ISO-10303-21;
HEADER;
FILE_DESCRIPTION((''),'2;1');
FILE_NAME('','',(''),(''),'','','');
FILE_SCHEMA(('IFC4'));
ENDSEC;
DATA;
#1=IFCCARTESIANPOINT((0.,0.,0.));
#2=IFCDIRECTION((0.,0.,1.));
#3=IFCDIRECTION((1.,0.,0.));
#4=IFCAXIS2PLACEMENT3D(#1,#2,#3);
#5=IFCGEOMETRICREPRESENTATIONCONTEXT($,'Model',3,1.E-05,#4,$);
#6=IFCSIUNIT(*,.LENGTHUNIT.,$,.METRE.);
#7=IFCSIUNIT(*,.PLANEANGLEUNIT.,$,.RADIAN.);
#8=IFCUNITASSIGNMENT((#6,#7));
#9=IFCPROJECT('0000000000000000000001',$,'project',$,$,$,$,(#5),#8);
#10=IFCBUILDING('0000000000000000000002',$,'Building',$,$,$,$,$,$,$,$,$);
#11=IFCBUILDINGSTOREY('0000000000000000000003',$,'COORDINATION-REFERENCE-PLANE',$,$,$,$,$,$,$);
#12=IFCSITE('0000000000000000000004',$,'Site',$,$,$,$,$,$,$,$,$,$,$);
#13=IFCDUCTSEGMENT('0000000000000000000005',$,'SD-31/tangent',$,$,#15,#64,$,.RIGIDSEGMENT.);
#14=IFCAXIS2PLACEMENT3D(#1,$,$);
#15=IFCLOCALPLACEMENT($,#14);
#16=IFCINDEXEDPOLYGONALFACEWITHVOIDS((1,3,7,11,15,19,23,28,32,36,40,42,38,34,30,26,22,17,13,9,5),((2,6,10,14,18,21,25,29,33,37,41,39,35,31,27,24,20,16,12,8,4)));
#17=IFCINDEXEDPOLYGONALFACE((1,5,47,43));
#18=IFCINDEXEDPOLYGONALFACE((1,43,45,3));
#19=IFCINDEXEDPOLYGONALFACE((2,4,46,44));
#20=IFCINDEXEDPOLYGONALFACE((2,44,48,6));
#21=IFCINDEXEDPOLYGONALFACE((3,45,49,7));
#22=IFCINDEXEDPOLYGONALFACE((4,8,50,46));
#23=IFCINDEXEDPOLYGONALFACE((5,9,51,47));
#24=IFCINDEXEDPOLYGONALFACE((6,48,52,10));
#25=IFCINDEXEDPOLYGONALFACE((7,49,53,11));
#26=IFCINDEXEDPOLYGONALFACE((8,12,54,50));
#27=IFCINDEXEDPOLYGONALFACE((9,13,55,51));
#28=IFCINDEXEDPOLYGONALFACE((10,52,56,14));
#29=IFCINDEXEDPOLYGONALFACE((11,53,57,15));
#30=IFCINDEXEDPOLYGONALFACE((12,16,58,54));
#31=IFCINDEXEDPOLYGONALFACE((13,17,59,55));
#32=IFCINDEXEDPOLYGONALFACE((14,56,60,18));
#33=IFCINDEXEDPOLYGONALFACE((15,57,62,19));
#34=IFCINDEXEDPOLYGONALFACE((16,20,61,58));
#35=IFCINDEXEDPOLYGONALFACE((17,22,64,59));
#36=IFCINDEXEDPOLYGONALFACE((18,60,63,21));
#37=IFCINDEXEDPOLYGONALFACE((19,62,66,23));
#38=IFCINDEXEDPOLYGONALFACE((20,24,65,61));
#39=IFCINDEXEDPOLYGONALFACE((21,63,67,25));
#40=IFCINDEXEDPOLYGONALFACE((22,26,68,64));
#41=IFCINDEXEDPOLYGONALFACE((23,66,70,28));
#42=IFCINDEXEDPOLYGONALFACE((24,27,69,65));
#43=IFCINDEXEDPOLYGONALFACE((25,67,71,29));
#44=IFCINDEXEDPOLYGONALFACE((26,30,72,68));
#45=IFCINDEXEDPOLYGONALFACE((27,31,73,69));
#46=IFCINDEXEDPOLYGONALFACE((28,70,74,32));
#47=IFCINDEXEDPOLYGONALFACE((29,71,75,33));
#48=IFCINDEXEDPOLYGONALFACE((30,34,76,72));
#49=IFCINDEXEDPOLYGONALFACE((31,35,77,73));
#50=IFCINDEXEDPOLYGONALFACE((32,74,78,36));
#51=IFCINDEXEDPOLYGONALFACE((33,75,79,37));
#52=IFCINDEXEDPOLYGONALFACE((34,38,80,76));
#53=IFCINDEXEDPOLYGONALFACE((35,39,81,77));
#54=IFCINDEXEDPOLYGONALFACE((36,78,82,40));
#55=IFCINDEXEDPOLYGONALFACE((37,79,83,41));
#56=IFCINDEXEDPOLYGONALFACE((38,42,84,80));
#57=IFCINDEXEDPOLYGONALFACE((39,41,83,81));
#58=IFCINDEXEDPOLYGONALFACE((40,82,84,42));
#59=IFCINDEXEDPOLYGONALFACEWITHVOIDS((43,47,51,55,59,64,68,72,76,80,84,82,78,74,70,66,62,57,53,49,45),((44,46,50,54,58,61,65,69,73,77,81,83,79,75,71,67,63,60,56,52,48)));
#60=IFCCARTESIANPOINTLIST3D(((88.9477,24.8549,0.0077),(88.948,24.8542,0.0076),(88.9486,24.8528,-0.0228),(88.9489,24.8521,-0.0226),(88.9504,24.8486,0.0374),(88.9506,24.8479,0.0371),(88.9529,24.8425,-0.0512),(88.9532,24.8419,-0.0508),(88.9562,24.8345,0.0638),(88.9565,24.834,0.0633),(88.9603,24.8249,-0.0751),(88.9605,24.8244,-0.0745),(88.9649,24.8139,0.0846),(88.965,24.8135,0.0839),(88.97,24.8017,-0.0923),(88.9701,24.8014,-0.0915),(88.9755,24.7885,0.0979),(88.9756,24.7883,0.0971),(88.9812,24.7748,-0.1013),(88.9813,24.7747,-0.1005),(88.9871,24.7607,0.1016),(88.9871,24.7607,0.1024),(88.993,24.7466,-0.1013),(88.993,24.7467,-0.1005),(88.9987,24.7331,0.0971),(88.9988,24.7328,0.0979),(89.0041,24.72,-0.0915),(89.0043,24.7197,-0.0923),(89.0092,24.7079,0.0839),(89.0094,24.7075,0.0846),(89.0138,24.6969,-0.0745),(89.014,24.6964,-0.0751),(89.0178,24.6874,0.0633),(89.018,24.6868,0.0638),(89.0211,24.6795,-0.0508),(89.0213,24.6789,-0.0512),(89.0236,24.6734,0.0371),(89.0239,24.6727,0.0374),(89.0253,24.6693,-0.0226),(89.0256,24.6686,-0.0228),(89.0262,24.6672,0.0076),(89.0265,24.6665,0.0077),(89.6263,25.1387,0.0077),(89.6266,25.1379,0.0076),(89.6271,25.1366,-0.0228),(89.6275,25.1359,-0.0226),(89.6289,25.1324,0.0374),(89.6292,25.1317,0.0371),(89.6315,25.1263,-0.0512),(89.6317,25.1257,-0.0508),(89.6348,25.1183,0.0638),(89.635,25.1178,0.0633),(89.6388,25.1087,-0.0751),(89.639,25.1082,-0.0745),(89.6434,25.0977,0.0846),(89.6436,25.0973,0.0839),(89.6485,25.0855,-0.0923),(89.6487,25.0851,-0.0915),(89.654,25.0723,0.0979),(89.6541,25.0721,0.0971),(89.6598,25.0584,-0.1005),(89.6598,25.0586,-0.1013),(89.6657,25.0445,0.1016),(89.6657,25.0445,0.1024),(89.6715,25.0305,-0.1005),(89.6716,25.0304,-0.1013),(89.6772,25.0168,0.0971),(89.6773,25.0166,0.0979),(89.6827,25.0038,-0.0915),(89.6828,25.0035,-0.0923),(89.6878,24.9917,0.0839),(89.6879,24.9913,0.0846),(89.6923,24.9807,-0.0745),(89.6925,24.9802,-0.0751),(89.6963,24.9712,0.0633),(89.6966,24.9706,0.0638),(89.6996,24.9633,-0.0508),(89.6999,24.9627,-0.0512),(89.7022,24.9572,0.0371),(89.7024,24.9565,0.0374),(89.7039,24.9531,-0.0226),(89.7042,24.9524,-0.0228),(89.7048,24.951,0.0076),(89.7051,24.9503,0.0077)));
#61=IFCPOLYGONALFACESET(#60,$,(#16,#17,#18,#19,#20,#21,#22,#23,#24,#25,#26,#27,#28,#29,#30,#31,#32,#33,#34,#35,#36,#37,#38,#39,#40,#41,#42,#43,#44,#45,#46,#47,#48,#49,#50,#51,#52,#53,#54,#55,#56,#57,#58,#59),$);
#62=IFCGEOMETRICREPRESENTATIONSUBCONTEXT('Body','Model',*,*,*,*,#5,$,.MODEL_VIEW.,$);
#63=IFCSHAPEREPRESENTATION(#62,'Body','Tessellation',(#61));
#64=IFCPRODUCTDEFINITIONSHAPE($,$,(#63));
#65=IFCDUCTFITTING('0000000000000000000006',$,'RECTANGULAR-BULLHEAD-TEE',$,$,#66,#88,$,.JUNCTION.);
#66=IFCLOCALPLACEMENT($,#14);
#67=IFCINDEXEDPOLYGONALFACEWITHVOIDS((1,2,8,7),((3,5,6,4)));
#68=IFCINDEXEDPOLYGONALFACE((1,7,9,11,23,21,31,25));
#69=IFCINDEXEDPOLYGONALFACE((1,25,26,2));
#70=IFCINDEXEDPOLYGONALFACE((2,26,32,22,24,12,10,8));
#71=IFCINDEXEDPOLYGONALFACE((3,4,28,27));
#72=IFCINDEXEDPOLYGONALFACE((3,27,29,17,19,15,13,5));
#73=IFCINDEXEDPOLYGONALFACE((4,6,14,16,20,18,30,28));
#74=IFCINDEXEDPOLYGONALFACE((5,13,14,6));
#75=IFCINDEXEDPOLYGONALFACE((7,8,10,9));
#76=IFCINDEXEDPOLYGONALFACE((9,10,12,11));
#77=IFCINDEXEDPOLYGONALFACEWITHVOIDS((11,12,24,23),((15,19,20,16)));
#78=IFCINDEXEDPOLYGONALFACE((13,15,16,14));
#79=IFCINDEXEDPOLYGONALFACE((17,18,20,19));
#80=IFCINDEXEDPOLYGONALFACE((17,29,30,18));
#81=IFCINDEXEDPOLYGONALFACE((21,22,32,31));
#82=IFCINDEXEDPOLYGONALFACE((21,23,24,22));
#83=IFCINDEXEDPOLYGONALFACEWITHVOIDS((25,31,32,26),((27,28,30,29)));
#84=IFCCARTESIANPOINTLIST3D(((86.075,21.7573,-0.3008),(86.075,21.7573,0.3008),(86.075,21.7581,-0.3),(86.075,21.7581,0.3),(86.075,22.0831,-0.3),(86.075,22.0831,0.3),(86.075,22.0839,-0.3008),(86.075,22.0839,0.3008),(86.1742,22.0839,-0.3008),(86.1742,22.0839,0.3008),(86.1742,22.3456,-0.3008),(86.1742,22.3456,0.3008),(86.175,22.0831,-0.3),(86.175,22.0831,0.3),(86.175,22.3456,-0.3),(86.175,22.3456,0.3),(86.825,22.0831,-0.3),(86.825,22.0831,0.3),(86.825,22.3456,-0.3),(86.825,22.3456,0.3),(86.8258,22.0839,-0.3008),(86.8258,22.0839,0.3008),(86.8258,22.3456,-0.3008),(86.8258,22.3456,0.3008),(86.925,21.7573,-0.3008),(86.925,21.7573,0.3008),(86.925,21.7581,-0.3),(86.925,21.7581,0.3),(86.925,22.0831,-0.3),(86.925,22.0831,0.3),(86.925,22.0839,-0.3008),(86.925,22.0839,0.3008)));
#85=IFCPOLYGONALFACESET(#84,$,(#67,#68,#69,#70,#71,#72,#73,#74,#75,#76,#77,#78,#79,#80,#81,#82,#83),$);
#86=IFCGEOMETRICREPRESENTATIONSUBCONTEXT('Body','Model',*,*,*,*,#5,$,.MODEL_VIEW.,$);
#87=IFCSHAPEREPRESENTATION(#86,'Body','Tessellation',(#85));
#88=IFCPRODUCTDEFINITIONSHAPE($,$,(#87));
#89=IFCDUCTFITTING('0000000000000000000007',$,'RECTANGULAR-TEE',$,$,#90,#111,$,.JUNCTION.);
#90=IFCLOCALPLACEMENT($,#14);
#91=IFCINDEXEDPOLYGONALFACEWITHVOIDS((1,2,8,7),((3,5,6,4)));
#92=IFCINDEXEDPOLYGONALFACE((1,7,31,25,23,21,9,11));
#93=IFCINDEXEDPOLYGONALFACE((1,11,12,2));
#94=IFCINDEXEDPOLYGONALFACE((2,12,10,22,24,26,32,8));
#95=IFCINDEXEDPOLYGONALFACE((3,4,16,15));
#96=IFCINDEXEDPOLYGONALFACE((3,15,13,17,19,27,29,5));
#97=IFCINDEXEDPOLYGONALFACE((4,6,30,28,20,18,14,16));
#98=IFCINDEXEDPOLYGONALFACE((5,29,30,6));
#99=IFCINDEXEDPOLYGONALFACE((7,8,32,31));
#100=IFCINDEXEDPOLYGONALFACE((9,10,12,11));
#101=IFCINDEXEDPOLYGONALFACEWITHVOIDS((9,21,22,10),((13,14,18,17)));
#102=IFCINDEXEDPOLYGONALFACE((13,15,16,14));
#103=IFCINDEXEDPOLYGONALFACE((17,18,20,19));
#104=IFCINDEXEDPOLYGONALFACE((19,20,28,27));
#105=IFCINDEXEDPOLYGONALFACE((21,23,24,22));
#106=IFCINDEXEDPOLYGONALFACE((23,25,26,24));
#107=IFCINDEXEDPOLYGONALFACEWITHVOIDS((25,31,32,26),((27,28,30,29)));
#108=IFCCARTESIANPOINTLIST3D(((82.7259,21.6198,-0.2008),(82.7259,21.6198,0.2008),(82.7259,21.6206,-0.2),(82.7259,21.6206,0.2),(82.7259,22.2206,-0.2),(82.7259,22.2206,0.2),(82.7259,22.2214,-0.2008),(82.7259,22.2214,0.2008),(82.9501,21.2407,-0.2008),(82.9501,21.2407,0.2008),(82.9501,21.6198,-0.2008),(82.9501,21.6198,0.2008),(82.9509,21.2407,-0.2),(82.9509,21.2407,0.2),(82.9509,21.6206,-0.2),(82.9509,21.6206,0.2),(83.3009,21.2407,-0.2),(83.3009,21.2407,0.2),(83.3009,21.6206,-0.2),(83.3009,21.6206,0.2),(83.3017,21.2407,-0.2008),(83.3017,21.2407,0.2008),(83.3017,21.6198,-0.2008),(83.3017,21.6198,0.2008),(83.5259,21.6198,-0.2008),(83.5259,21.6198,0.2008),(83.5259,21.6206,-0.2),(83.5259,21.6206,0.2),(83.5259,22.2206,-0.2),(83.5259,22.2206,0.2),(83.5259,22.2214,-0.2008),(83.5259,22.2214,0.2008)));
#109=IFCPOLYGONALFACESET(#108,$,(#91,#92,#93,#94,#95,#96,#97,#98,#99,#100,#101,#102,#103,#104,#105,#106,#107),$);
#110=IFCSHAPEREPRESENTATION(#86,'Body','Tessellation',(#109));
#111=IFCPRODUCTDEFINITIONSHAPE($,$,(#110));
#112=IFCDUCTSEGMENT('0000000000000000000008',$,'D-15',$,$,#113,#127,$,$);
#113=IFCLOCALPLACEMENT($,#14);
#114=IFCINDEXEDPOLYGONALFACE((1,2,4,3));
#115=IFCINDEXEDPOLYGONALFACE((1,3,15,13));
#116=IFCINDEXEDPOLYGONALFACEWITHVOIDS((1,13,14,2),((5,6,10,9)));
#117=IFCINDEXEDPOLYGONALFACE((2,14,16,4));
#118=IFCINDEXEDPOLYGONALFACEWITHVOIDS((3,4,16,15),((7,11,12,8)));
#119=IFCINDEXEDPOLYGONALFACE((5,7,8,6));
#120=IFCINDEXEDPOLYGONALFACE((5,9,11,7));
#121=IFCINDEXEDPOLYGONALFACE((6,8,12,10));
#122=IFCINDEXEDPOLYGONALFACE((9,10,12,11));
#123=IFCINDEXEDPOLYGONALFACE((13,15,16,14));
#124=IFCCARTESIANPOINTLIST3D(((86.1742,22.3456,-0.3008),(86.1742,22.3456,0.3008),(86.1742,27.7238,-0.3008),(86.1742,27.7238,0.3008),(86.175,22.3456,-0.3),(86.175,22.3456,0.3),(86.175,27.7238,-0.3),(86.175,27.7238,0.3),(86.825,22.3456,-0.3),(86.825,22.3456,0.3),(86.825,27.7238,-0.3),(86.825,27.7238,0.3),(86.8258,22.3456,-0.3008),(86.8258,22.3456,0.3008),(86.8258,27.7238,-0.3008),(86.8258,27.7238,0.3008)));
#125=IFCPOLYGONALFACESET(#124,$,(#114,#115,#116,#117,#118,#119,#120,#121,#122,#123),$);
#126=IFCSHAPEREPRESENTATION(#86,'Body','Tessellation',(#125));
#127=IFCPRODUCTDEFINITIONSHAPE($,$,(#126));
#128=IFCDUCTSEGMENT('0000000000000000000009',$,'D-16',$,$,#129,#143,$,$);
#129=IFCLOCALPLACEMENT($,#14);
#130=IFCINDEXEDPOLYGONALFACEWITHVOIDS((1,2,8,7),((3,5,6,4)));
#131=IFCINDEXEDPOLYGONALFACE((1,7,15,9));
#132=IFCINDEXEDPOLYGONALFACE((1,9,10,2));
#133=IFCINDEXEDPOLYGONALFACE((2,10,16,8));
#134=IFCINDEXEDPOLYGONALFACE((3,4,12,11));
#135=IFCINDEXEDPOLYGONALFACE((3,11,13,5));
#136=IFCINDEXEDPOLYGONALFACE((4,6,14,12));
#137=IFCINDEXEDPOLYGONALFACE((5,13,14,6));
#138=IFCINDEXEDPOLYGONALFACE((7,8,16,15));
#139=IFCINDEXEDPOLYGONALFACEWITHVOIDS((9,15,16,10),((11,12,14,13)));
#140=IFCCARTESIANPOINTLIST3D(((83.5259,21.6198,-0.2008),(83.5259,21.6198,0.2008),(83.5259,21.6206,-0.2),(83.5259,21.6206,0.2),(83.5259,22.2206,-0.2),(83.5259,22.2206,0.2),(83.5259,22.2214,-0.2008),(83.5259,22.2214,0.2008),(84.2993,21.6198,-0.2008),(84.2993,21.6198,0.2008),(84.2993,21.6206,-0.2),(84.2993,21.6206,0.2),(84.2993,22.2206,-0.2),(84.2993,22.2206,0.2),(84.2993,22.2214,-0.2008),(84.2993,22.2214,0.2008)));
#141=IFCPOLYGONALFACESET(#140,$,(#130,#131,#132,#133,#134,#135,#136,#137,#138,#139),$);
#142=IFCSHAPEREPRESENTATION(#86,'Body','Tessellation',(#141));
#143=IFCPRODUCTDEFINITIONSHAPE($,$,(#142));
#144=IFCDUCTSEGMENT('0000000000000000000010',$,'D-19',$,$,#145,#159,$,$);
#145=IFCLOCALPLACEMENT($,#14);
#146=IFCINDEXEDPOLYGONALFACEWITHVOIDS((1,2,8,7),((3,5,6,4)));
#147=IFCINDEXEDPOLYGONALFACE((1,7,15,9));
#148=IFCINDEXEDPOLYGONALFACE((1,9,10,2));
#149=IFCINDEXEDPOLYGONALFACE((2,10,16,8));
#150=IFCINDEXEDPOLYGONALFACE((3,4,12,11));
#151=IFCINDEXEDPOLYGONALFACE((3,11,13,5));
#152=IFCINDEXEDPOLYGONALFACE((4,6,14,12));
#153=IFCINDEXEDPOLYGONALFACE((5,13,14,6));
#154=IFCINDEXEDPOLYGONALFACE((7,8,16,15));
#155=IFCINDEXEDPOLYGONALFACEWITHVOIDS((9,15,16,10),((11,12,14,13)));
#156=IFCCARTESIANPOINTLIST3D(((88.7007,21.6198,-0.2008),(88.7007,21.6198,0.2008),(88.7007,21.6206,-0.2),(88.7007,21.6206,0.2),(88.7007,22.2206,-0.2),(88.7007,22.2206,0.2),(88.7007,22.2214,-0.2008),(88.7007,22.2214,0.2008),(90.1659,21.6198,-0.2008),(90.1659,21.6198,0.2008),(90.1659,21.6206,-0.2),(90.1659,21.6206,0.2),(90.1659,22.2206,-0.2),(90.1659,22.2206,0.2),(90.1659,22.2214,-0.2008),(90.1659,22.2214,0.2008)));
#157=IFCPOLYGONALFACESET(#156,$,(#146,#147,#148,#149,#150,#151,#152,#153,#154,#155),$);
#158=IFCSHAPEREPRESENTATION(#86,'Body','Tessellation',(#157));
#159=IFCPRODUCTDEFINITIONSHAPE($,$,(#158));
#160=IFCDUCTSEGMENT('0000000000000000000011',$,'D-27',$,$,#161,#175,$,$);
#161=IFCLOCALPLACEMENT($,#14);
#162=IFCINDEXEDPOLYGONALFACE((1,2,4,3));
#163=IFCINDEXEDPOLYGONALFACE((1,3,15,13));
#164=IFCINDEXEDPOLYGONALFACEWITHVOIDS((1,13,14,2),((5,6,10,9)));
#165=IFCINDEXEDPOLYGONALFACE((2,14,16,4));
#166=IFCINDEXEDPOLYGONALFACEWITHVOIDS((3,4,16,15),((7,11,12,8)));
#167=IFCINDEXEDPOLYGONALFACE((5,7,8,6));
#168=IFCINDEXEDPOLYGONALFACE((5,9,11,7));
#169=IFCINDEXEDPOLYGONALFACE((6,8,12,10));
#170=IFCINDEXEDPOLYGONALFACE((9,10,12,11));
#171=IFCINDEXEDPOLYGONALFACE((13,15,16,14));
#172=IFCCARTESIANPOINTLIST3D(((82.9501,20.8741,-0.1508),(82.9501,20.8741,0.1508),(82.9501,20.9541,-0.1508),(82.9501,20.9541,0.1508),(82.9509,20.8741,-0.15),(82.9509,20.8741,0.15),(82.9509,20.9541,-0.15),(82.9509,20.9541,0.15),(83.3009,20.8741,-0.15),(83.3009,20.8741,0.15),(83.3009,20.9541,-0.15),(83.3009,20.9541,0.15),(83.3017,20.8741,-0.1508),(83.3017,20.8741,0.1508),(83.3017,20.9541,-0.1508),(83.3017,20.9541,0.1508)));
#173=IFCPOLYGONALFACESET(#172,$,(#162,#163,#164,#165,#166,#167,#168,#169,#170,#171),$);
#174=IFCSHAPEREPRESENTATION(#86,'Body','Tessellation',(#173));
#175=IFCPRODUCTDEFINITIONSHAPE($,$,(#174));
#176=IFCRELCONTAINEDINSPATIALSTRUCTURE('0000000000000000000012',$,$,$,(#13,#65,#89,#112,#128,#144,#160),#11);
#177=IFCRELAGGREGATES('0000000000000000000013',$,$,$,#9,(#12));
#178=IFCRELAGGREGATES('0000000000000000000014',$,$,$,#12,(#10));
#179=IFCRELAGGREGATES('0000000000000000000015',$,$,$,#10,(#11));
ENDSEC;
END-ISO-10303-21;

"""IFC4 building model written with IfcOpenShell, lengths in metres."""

from ifc_helpers import new_model, si_unit, frame, origin, origin_with_axes, place, context, subcontext, project, spatial, rectangle, hollow_rectangle, hollow_circle, extrude, boolean, element, save


model = new_model("IFC4")

# Units and contexts
model_context = context("Model", 3, precision=1e-05, world=origin_with_axes())
body_context_1 = subcontext(model_context, "Body", "Model", "MODEL_VIEW")
body_context_2 = subcontext(model_context, "Body", "Model", "MODEL_VIEW")
ifc_project = project(units=[si_unit("LENGTHUNIT", "METRE"), si_unit("PLANEANGLEUNIT", "RADIAN")], contexts=[model_context])

# Site, building, storey
site = spatial("IfcSite", under=ifc_project, Name="Site")
building = spatial("IfcBuilding", under=site, Name="Building")
storey = spatial("IfcBuildingStorey", under=building, Name="COORDINATION-REFERENCE-PLANE")

# Duct segment
duct_segment_1_placement = place(None, frame((89.6657, 25.0445, 0.0), z_axis=(-0.922564, -0.385845, 0.0), x_axis=(0.0, 0.0, 1.0)))
element("IfcDuctSegment", 1, at=duct_segment_1_placement, inside=storey, Name="SD-31/tangent", PredefinedType="RIGIDSEGMENT", context=body_context_1, shape_type="SweptSolid", body=[
    extrude(hollow_circle(Radius=0.1024, WallThickness=0.0008), origin_with_axes(), (0.0, 0.0, 1.0), 0.7355),
])

# Duct fittings
duct_fitting_1_placement = place(None, frame((86.5, 21.9206, 0.0), z_axis=(1.0, 0.0, 0.0), x_axis=(0.0, 1.0, 0.0)))
solid_1 = boolean("UNION", extrude(rectangle(XDim=0.325, YDim=0.6), frame((0.0, 0.0, -0.425), z_axis=(0.0, 0.0, 1.0), x_axis=(1.0, 0.0, 0.0)), (0.0, 0.0, 1.0), 0.85), extrude(rectangle(XDim=0.65, YDim=0.6), frame((0.0, 0.0, 0.0), z_axis=(1.0, 0.0, 0.0), x_axis=(0.0, 0.0, -1.0)), (0.0, 0.0, 1.0), 0.425))
element("IfcDuctFitting", 2, at=duct_fitting_1_placement, inside=storey, Name="RECTANGULAR-BULLHEAD-TEE", PredefinedType="JUNCTION", context=body_context_2, shape_type="CSG", body=[
    boolean("DIFFERENCE", boolean("UNION", extrude(rectangle(XDim=0.3266, YDim=0.6016), frame((0.0, 0.0, -0.425), z_axis=(0.0, 0.0, 1.0), x_axis=(1.0, 0.0, 0.0)), (0.0, 0.0, 1.0), 0.85), extrude(rectangle(XDim=0.6516, YDim=0.6016), frame((0.0, 0.0, 0.0), z_axis=(1.0, 0.0, 0.0), x_axis=(0.0, 0.0, -1.0)), (0.0, 0.0, 1.0), 0.425)), solid_1),
])
duct_fitting_2_placement = place(None, frame((83.1259, 21.9206, 0.0), z_axis=(-1.0, 0.0, 0.0), x_axis=(0.0, -1.0, 0.0)))
solid_2 = boolean("UNION", extrude(rectangle(XDim=0.6, YDim=0.4), frame((0.0, 0.0, -0.4), z_axis=(0.0, 0.0, 1.0), x_axis=(1.0, 0.0, 0.0)), (0.0, 0.0, 1.0), 0.8), extrude(rectangle(XDim=0.35, YDim=0.4), frame((0.0, 0.0, 0.0), z_axis=(1.0, 0.0, 0.0), x_axis=(0.0, 0.0, -1.0)), (0.0, 0.0, 1.0), 0.6799))
element("IfcDuctFitting", 3, at=duct_fitting_2_placement, inside=storey, Name="RECTANGULAR-TEE", PredefinedType="JUNCTION", context=body_context_2, shape_type="CSG", body=[
    boolean("DIFFERENCE", boolean("UNION", extrude(rectangle(XDim=0.6016, YDim=0.4016), frame((0.0, 0.0, -0.4), z_axis=(0.0, 0.0, 1.0), x_axis=(1.0, 0.0, 0.0)), (0.0, 0.0, 1.0), 0.8), extrude(rectangle(XDim=0.3516, YDim=0.4016), frame((0.0, 0.0, 0.0), z_axis=(1.0, 0.0, 0.0), x_axis=(0.0, 0.0, -1.0)), (0.0, 0.0, 1.0), 0.6799)), solid_2),
])

# Duct segments
duct_segment_2_placement = place(None, frame((86.5, 22.3456, 0.0), z_axis=(0.0, 1.0, 0.0), x_axis=(1.0, 0.0, 0.0)))
element("IfcDuctSegment", 4, at=duct_segment_2_placement, inside=storey, Name="D-15", context=body_context_2, shape_type="SweptSolid", body=[
    extrude(hollow_rectangle(XDim=0.6516, YDim=0.6016, WallThickness=0.0008), origin(), (0.0, 0.0, 1.0), 5.3782),
])
duct_segment_3_placement = place(None, frame((83.5259, 21.9206, 0.0), z_axis=(1.0, 0.0, 0.0), x_axis=(0.0, 1.0, 0.0)))
element("IfcDuctSegment", 5, at=duct_segment_3_placement, inside=storey, Name="D-16", context=body_context_2, shape_type="SweptSolid", body=[
    extrude(hollow_rectangle(XDim=0.6016, YDim=0.4016, WallThickness=0.0008), origin(), (0.0, 0.0, 1.0), 0.7733),
])
duct_segment_4_placement = place(None, frame((88.7007, 21.9206, 0.0), z_axis=(1.0, 0.0, 0.0), x_axis=(0.0, 1.0, 0.0)))
element("IfcDuctSegment", 6, at=duct_segment_4_placement, inside=storey, Name="D-19", context=body_context_2, shape_type="SweptSolid", body=[
    extrude(hollow_rectangle(XDim=0.6016, YDim=0.4016, WallThickness=0.0008), origin(), (0.0, 0.0, 1.0), 1.4652),
])
duct_segment_5_placement = place(None, frame((83.1259, 20.8741, 0.0), z_axis=(0.0, 1.0, 0.0), x_axis=(1.0, 0.0, 0.0)))
element("IfcDuctSegment", 7, at=duct_segment_5_placement, inside=storey, Name="D-27", context=body_context_2, shape_type="SweptSolid", body=[
    extrude(hollow_rectangle(XDim=0.3516, YDim=0.3016, WallThickness=0.0008), origin(), (0.0, 0.0, 1.0), 0.08),
])

save(model, "model.ifc")
